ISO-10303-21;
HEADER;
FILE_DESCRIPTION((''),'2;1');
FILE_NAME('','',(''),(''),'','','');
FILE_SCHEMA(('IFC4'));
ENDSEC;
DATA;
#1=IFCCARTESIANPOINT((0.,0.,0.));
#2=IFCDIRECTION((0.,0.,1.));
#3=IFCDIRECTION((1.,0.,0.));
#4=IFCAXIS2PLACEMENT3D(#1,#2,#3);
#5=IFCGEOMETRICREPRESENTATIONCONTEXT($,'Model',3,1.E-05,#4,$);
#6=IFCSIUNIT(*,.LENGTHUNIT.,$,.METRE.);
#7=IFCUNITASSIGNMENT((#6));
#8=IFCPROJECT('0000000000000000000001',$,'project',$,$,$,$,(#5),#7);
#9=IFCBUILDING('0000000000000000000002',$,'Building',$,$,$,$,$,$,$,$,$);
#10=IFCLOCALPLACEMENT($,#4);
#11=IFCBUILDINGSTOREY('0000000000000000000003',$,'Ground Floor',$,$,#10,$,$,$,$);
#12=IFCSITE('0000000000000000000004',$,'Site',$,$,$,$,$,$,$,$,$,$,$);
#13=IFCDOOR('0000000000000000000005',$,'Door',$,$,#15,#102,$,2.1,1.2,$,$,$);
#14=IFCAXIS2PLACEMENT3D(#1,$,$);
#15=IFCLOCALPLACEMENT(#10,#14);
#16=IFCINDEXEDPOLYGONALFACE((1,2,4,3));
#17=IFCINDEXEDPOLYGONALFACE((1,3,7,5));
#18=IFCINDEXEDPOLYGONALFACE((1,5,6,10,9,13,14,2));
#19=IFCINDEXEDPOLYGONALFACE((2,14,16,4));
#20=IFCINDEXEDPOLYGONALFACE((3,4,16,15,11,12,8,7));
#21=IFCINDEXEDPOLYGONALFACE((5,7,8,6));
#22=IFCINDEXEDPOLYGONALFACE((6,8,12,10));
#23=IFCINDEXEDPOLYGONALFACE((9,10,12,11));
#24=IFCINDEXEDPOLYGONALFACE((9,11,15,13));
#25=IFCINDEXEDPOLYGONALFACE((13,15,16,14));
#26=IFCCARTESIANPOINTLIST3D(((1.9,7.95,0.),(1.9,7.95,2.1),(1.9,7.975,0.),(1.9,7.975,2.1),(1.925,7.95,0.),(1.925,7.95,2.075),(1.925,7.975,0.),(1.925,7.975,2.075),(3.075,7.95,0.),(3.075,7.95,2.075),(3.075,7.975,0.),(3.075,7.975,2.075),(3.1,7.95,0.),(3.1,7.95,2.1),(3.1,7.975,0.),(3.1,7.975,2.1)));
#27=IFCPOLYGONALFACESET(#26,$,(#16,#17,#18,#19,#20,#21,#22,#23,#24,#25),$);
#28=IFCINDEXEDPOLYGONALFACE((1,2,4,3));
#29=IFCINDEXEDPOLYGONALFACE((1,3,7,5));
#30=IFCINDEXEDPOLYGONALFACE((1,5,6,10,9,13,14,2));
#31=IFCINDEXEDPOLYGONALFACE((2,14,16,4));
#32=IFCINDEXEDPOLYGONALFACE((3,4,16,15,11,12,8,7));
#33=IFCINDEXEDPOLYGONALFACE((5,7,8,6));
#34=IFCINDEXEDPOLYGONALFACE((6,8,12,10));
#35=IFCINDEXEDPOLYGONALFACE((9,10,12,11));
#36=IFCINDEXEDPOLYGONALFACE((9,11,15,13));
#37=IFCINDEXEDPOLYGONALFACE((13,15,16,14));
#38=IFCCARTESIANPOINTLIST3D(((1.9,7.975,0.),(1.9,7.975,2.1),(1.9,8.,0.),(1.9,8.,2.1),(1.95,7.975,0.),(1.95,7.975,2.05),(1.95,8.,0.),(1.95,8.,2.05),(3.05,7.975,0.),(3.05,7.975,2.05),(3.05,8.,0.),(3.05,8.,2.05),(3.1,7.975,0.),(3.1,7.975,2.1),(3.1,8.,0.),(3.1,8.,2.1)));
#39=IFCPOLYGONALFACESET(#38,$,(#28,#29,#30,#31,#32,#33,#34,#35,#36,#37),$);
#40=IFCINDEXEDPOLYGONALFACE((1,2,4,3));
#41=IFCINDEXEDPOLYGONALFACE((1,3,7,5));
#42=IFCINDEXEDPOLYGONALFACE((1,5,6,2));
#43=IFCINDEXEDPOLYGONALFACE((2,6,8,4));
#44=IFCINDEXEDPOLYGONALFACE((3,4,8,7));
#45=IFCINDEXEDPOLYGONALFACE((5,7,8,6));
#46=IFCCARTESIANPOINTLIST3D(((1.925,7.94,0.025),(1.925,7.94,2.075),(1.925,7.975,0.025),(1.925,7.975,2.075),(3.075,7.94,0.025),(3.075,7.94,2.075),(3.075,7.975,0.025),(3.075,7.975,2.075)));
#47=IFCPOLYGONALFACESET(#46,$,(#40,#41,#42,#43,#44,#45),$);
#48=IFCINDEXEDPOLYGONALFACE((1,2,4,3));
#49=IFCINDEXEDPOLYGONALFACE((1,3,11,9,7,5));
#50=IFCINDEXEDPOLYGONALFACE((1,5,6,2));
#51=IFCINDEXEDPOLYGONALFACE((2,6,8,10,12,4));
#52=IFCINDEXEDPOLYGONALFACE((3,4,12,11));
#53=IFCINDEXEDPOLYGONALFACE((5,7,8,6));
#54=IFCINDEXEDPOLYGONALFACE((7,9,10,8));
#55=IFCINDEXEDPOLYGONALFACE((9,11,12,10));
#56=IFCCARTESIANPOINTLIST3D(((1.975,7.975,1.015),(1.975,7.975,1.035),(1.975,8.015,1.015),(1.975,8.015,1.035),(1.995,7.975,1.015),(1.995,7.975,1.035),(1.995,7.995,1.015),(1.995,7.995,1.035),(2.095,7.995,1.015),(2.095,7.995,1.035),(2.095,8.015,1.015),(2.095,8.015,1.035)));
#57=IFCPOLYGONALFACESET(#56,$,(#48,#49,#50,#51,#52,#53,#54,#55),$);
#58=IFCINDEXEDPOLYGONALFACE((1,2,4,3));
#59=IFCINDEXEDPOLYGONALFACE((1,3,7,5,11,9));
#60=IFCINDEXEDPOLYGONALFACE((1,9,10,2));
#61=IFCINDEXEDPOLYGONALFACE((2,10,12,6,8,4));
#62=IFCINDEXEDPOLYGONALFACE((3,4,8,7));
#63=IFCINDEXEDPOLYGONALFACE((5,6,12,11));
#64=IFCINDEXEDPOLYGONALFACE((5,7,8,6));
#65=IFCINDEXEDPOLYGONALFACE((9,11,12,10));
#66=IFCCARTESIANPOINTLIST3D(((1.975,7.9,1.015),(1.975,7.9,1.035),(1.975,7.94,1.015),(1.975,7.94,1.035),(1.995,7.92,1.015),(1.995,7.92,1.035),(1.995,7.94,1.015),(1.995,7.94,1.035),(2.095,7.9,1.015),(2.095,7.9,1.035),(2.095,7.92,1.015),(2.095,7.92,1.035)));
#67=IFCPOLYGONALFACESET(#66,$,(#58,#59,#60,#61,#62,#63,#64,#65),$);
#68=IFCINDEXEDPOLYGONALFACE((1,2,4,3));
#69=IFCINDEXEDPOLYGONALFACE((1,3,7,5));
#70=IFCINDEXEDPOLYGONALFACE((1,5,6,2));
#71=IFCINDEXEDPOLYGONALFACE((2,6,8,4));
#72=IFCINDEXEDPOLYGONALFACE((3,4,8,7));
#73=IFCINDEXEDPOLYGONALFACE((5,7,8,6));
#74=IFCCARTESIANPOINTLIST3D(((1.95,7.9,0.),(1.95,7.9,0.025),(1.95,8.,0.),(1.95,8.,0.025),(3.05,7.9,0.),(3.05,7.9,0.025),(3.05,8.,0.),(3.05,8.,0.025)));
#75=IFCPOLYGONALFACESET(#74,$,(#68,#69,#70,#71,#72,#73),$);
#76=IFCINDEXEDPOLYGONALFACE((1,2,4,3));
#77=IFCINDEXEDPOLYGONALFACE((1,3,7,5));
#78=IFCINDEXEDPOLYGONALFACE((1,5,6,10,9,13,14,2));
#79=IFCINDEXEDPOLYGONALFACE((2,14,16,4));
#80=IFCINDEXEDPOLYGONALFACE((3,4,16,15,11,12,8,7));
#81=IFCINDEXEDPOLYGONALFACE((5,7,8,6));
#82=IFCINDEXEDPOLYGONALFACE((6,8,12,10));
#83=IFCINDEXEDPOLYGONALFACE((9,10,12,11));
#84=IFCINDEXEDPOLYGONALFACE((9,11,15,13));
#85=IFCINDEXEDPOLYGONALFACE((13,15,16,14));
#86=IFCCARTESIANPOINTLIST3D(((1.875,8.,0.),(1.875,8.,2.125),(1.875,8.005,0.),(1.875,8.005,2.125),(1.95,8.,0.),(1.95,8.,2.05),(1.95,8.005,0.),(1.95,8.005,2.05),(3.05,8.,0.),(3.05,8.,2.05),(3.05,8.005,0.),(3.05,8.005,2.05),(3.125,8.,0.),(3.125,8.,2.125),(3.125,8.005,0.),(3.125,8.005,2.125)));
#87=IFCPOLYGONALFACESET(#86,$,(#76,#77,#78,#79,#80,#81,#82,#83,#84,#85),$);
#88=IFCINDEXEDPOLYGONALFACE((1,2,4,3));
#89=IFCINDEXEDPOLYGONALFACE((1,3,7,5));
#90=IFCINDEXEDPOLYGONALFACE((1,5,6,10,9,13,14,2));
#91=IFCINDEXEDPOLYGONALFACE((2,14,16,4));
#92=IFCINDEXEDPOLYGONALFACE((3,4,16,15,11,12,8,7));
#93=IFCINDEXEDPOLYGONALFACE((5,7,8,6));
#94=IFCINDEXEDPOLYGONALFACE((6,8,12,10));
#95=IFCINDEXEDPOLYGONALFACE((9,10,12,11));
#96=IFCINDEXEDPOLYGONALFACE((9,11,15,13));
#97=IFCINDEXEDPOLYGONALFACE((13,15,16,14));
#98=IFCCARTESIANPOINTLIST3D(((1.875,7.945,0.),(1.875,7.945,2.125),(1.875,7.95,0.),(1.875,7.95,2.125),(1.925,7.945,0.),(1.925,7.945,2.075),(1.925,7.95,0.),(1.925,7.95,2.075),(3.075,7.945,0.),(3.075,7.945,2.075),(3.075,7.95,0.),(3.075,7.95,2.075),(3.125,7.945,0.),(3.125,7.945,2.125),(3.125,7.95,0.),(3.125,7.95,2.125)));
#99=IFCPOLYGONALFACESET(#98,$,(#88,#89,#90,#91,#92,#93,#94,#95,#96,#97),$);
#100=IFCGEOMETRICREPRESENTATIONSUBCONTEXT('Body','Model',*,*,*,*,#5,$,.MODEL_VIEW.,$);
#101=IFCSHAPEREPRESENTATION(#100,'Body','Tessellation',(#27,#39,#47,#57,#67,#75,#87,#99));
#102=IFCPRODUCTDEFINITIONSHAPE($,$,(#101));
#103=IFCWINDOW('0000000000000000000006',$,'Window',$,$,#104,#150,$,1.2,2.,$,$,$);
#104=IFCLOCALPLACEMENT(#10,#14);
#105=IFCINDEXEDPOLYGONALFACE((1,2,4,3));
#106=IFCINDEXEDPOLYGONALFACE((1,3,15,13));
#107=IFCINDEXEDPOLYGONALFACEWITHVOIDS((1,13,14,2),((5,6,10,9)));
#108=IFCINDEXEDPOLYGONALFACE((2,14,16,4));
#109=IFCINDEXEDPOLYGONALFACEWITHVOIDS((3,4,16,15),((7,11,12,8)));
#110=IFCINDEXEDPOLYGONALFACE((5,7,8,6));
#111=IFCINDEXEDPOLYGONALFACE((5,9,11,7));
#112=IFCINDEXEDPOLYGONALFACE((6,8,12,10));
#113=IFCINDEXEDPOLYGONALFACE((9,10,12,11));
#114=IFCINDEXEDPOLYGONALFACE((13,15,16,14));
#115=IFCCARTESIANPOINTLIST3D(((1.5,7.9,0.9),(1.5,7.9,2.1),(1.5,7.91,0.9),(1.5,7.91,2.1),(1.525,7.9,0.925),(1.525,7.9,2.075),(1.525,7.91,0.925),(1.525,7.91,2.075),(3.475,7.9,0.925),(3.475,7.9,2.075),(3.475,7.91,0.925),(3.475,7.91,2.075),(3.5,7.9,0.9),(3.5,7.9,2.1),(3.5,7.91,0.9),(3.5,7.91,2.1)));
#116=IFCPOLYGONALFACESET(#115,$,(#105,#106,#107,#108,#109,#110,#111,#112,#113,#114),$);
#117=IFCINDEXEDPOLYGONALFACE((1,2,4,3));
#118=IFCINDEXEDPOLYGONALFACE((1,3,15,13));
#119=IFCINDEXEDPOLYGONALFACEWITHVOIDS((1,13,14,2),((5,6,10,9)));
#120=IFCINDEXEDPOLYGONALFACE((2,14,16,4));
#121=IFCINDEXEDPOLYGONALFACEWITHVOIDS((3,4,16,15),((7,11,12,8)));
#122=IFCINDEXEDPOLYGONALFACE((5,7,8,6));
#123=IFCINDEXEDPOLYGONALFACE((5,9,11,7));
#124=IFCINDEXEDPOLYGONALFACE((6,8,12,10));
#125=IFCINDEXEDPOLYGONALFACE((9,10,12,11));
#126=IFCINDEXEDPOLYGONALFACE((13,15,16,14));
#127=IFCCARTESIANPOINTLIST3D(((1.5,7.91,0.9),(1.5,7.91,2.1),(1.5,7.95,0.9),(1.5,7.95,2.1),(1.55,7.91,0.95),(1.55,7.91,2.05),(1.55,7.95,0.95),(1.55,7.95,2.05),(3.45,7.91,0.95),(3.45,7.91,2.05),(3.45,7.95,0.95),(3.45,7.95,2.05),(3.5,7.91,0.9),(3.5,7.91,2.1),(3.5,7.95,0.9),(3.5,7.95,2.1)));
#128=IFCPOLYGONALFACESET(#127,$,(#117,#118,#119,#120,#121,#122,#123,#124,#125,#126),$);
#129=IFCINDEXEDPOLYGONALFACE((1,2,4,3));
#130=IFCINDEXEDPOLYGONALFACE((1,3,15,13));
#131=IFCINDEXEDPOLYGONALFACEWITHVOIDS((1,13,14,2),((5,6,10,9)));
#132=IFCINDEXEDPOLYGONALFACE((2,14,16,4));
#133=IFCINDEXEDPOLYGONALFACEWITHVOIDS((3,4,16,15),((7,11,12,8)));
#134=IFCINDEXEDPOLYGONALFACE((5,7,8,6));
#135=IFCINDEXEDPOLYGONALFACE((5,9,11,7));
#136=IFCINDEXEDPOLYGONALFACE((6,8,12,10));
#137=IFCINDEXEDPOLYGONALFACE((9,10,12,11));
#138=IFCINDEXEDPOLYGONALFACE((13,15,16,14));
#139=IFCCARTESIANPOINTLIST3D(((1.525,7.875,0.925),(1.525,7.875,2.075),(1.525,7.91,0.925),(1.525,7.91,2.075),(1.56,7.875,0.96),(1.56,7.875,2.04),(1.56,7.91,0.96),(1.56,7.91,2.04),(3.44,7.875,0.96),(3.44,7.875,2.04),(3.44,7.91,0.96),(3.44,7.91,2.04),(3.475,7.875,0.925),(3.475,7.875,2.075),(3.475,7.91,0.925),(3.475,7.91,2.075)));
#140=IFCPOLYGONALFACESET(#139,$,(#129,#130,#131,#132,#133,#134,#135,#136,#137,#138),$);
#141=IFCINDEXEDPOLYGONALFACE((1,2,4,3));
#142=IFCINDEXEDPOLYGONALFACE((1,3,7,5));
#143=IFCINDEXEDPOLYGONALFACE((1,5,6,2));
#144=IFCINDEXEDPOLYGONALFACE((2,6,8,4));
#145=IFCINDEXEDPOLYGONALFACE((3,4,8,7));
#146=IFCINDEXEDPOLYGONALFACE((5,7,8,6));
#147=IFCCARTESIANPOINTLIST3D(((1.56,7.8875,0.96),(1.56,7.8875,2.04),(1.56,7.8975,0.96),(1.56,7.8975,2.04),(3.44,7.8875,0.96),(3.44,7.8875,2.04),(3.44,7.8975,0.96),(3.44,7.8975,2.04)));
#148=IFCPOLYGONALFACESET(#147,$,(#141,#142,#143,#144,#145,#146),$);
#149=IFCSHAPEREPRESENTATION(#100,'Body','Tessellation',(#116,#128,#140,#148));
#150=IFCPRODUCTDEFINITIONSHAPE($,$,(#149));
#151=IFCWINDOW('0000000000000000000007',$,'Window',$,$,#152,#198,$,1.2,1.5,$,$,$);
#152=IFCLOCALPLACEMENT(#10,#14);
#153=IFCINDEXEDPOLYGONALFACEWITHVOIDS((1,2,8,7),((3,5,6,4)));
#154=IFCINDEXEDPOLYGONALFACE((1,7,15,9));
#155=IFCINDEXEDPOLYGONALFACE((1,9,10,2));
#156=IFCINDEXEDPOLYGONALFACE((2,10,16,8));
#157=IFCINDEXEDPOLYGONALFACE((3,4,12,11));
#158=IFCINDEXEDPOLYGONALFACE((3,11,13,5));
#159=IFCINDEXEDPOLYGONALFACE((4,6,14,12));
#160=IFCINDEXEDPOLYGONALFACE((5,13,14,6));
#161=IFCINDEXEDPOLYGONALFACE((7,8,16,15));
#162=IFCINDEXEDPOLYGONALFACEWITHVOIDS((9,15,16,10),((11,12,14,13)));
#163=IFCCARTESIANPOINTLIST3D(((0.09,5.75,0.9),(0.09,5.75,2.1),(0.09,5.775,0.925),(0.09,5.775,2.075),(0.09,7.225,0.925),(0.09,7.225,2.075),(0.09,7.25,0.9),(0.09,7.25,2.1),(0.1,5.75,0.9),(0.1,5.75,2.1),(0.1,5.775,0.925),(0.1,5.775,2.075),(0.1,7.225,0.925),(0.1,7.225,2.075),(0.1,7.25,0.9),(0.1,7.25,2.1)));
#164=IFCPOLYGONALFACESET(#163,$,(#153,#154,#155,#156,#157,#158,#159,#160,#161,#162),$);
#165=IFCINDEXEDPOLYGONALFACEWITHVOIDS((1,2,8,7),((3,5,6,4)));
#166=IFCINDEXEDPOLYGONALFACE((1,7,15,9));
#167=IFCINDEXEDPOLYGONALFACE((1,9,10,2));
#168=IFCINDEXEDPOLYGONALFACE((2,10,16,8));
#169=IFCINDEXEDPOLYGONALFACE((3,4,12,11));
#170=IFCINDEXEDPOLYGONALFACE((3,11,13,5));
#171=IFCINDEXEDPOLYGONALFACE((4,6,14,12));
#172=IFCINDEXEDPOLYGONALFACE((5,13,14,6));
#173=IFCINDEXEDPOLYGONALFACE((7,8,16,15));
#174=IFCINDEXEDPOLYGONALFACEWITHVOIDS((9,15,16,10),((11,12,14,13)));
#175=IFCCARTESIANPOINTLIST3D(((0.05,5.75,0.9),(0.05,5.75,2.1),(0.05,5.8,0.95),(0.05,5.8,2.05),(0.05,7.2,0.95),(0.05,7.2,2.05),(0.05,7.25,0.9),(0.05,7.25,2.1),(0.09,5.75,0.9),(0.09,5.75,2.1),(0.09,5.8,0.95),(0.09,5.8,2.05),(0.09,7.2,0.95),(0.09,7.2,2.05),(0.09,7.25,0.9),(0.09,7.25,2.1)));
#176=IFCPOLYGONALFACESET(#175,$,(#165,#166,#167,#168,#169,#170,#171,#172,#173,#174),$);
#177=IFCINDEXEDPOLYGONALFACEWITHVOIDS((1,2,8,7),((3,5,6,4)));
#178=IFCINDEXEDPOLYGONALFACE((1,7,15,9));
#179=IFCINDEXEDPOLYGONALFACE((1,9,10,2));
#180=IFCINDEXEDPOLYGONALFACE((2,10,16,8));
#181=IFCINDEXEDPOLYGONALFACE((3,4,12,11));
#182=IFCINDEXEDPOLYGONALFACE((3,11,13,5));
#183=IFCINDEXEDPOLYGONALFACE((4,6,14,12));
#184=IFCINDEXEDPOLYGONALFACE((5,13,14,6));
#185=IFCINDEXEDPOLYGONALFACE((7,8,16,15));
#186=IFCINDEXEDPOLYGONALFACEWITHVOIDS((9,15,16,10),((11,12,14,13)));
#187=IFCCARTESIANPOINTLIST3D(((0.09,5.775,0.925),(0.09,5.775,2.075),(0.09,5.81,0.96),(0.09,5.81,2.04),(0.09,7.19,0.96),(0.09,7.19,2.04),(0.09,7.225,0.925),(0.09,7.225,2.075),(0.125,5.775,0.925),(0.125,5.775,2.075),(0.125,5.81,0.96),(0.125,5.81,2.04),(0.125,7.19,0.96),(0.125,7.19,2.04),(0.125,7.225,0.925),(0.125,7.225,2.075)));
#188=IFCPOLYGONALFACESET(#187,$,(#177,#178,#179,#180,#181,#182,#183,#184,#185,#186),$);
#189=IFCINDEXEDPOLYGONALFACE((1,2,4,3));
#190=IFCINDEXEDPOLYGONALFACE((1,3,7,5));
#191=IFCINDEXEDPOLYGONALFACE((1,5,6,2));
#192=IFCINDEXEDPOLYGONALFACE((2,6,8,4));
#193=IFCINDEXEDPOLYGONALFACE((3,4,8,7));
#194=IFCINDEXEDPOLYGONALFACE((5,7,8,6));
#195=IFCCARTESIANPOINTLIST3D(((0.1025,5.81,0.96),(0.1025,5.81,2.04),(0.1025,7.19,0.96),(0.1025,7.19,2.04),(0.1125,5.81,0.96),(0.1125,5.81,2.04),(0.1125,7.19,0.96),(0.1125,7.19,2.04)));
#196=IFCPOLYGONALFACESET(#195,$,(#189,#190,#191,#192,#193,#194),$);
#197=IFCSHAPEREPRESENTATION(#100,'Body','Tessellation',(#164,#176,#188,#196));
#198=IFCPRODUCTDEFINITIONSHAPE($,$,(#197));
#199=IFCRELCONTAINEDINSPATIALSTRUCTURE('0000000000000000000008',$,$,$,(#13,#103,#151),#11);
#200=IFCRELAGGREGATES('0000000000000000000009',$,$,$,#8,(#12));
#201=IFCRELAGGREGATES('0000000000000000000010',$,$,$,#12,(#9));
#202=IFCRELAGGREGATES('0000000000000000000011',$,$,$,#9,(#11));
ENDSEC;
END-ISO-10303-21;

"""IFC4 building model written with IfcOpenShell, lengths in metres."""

from ifc_helpers import new_model, si_unit, frame, origin_with_axes, place, context, subcontext, project, spatial, line, indexed_curve, outline, extrude, element, save


model = new_model("IFC4")

# Units and contexts
model_context = context("Model", 3, precision=1e-05, world=origin_with_axes())
body_context = subcontext(model_context, "Body", "Model", "MODEL_VIEW")
ifc_project = project(units=[si_unit("LENGTHUNIT", "METRE")], contexts=[model_context])

# Site, building, storey
site = spatial("IfcSite", under=ifc_project, Name="Site")
building = spatial("IfcBuilding", under=site, Name="Building")
storey_placement = place(None, origin_with_axes())
storey = spatial("IfcBuildingStorey", under=building, at=storey_placement, Name="Ground Floor")

# Door
door_1_placement = place(storey_placement, frame((3.1, 8.0, 0.0), z_axis=(0.0, 0.0, 1.0), x_axis=(-1.0, 0.0, 0.0)))
element("IfcDoor", 1, at=door_1_placement, inside=storey, Name="Door", OverallHeight=2.1, OverallWidth=1.2, context=body_context, shape_type="SweptSolid", body=[
    extrude(outline(indexed_curve([(0.0, 0.0), (0.0, 2.1), (1.2, 2.1), (1.2, 0.0), (1.175, 0.0), (1.175, 2.075), (0.025, 2.075), (0.025, 0.0)], segments=[line(1, 2, 3, 4, 5, 6, 7, 8, 1)])), frame((0.0, 0.025, 0.0), z_axis=(0.0, -1.0, 0.0), x_axis=(1.0, 0.0, 0.0)), (0.0, 0.0, -1.0), 0.025),
    extrude(outline(indexed_curve([(0.0, 0.0), (0.0, 2.1), (1.2, 2.1), (1.2, 0.0), (1.15, 0.0), (1.15, 2.05), (0.05, 2.05), (0.05, 0.0)], segments=[line(1, 2, 3, 4, 5, 6, 7, 8, 1)])), frame((0.0, 0.0, 0.0), z_axis=(0.0, -1.0, 0.0), x_axis=(1.0, 0.0, 0.0)), (0.0, 0.0, -1.0), 0.025),
    extrude(outline(indexed_curve([(0.0, 0.0), (1.15, 0.0), (1.15, 0.035), (0.0, 0.035)], segments=[line(1, 2, 3, 4, 1)])), frame((0.025, 0.025, 0.025), z_axis=(0.0, 0.0, 1.0), x_axis=(1.0, 0.0, 0.0)), (0.0, 0.0, 1.0), 2.05),
    extrude(outline(indexed_curve([(0.0, 0.0), (0.0, -0.04), (-0.12, -0.04), (-0.12, -0.02), (-0.02, -0.02), (-0.02, 0.0)], segments=[line(1, 2, 3, 4, 5, 6, 1)])), frame((1.125, 0.025, 1.015), z_axis=(0.0, 0.0, 1.0), x_axis=(1.0, 0.0, 0.0)), (0.0, 0.0, 1.0), 0.02),
    extrude(outline(indexed_curve([(0.0, 0.0), (0.0, 0.04), (-0.12, 0.04), (-0.12, 0.02), (-0.02, 0.02), (-0.02, 0.0)], segments=[line(1, 2, 3, 4, 5, 6, 1)])), frame((1.125, 0.06, 1.015), z_axis=(0.0, 0.0, 1.0), x_axis=(1.0, 0.0, 0.0)), (0.0, 0.0, 1.0), 0.02),
    extrude(outline(indexed_curve([(0.0, 0.0), (1.1, 0.0), (1.1, 0.1), (0.0, 0.1)], segments=[line(1, 2, 3, 4, 1)])), frame((0.05, 0.0, 0.0), z_axis=(0.0, 0.0, 1.0), x_axis=(1.0, 0.0, 0.0)), (0.0, 0.0, 1.0), 0.025),
    extrude(outline(indexed_curve([(0.0, 0.0), (0.0, 2.125), (1.25, 2.125), (1.25, 0.0), (1.175, 0.0), (1.175, 2.05), (0.075, 2.05), (0.075, 0.0)], segments=[line(1, 2, 3, 4, 5, 6, 7, 8, 1)])), frame((-0.025, -0.005, 0.0), z_axis=(0.0, -1.0, 0.0), x_axis=(1.0, 0.0, 0.0)), (0.0, 0.0, -1.0), 0.005),
    extrude(outline(indexed_curve([(0.0, 0.0), (0.0, 2.125), (1.25, 2.125), (1.25, 0.0), (1.2, 0.0), (1.2, 2.075), (0.05, 2.075), (0.05, 0.0)], segments=[line(1, 2, 3, 4, 5, 6, 7, 8, 1)])), frame((-0.025, 0.05, 0.0), z_axis=(0.0, -1.0, 0.0), x_axis=(1.0, 0.0, 0.0)), (0.0, 0.0, -1.0), 0.005),
])

# Windows
window_1_placement = place(storey_placement, frame((3.5, 8.0, 0.9), z_axis=(0.0, 0.0, 1.0), x_axis=(-1.0, 0.0, 0.0)))
element("IfcWindow", 2, at=window_1_placement, inside=storey, Name="Window", OverallHeight=1.2, OverallWidth=2.0, context=body_context, shape_type="SweptSolid", body=[
    extrude(outline(indexed_curve([(0.0, 0.0), (2.0, 0.0), (2.0, 1.2), (0.0, 1.2)], segments=[line(1, 2, 3, 4, 1)]), holes=[indexed_curve([(0.025, 0.025), (1.975, 0.025), (1.975, 1.175), (0.025, 1.175)], segments=[line(1, 2, 3, 4, 1)])]), frame((0.0, 0.09, 0.0), z_axis=(0.0, -1.0, 0.0), x_axis=(1.0, 0.0, 0.0)), (0.0, 0.0, -1.0), 0.01),
    extrude(outline(indexed_curve([(0.0, 0.0), (2.0, 0.0), (2.0, 1.2), (0.0, 1.2)], segments=[line(1, 2, 3, 4, 1)]), holes=[indexed_curve([(0.05, 0.05), (1.95, 0.05), (1.95, 1.15), (0.05, 1.15)], segments=[line(1, 2, 3, 4, 1)])]), frame((0.0, 0.05, 0.0), z_axis=(0.0, -1.0, 0.0), x_axis=(1.0, 0.0, 0.0)), (0.0, 0.0, -1.0), 0.04),
    extrude(outline(indexed_curve([(0.0, 0.0), (1.95, 0.0), (1.95, 1.15), (0.0, 1.15)], segments=[line(1, 2, 3, 4, 1)]), holes=[indexed_curve([(0.035, 0.035), (1.915, 0.035), (1.915, 1.115), (0.035, 1.115)], segments=[line(1, 2, 3, 4, 1)])]), frame((0.025, 0.09, 0.025), z_axis=(0.0, -1.0, 0.0), x_axis=(1.0, 0.0, 0.0)), (0.0, 0.0, -1.0), 0.035),
    extrude(outline(indexed_curve([(0.035, 0.035), (1.915, 0.035), (1.915, 1.115), (0.035, 1.115)], segments=[line(1, 2, 3, 4, 1)])), frame((0.025, 0.1025, 0.025), z_axis=(0.0, -1.0, 0.0), x_axis=(1.0, 0.0, 0.0)), (0.0, 0.0, -1.0), 0.01),
])
window_2_placement = place(storey_placement, frame((0.0, 7.25, 0.9), z_axis=(0.0, 0.0, 1.0), x_axis=(0.0, -1.0, 0.0)))
element("IfcWindow", 3, at=window_2_placement, inside=storey, Name="Window", OverallHeight=1.2, OverallWidth=1.5, context=body_context, shape_type="SweptSolid", body=[
    extrude(outline(indexed_curve([(0.0, 0.0), (1.5, 0.0), (1.5, 1.2), (0.0, 1.2)], segments=[line(1, 2, 3, 4, 1)]), holes=[indexed_curve([(0.025, 0.025), (1.475, 0.025), (1.475, 1.175), (0.025, 1.175)], segments=[line(1, 2, 3, 4, 1)])]), frame((0.0, 0.09, 0.0), z_axis=(0.0, -1.0, 0.0), x_axis=(1.0, 0.0, 0.0)), (0.0, 0.0, -1.0), 0.01),
    extrude(outline(indexed_curve([(0.0, 0.0), (1.5, 0.0), (1.5, 1.2), (0.0, 1.2)], segments=[line(1, 2, 3, 4, 1)]), holes=[indexed_curve([(0.05, 0.05), (1.45, 0.05), (1.45, 1.15), (0.05, 1.15)], segments=[line(1, 2, 3, 4, 1)])]), frame((0.0, 0.05, 0.0), z_axis=(0.0, -1.0, 0.0), x_axis=(1.0, 0.0, 0.0)), (0.0, 0.0, -1.0), 0.04),
    extrude(outline(indexed_curve([(0.0, 0.0), (1.45, 0.0), (1.45, 1.15), (0.0, 1.15)], segments=[line(1, 2, 3, 4, 1)]), holes=[indexed_curve([(0.035, 0.035), (1.415, 0.035), (1.415, 1.115), (0.035, 1.115)], segments=[line(1, 2, 3, 4, 1)])]), frame((0.025, 0.09, 0.025), z_axis=(0.0, -1.0, 0.0), x_axis=(1.0, 0.0, 0.0)), (0.0, 0.0, -1.0), 0.035),
    extrude(outline(indexed_curve([(0.035, 0.035), (1.415, 0.035), (1.415, 1.115), (0.035, 1.115)], segments=[line(1, 2, 3, 4, 1)])), frame((0.025, 0.1025, 0.025), z_axis=(0.0, -1.0, 0.0), x_axis=(1.0, 0.0, 0.0)), (0.0, 0.0, -1.0), 0.01),
])

save(model, "model.ifc")
